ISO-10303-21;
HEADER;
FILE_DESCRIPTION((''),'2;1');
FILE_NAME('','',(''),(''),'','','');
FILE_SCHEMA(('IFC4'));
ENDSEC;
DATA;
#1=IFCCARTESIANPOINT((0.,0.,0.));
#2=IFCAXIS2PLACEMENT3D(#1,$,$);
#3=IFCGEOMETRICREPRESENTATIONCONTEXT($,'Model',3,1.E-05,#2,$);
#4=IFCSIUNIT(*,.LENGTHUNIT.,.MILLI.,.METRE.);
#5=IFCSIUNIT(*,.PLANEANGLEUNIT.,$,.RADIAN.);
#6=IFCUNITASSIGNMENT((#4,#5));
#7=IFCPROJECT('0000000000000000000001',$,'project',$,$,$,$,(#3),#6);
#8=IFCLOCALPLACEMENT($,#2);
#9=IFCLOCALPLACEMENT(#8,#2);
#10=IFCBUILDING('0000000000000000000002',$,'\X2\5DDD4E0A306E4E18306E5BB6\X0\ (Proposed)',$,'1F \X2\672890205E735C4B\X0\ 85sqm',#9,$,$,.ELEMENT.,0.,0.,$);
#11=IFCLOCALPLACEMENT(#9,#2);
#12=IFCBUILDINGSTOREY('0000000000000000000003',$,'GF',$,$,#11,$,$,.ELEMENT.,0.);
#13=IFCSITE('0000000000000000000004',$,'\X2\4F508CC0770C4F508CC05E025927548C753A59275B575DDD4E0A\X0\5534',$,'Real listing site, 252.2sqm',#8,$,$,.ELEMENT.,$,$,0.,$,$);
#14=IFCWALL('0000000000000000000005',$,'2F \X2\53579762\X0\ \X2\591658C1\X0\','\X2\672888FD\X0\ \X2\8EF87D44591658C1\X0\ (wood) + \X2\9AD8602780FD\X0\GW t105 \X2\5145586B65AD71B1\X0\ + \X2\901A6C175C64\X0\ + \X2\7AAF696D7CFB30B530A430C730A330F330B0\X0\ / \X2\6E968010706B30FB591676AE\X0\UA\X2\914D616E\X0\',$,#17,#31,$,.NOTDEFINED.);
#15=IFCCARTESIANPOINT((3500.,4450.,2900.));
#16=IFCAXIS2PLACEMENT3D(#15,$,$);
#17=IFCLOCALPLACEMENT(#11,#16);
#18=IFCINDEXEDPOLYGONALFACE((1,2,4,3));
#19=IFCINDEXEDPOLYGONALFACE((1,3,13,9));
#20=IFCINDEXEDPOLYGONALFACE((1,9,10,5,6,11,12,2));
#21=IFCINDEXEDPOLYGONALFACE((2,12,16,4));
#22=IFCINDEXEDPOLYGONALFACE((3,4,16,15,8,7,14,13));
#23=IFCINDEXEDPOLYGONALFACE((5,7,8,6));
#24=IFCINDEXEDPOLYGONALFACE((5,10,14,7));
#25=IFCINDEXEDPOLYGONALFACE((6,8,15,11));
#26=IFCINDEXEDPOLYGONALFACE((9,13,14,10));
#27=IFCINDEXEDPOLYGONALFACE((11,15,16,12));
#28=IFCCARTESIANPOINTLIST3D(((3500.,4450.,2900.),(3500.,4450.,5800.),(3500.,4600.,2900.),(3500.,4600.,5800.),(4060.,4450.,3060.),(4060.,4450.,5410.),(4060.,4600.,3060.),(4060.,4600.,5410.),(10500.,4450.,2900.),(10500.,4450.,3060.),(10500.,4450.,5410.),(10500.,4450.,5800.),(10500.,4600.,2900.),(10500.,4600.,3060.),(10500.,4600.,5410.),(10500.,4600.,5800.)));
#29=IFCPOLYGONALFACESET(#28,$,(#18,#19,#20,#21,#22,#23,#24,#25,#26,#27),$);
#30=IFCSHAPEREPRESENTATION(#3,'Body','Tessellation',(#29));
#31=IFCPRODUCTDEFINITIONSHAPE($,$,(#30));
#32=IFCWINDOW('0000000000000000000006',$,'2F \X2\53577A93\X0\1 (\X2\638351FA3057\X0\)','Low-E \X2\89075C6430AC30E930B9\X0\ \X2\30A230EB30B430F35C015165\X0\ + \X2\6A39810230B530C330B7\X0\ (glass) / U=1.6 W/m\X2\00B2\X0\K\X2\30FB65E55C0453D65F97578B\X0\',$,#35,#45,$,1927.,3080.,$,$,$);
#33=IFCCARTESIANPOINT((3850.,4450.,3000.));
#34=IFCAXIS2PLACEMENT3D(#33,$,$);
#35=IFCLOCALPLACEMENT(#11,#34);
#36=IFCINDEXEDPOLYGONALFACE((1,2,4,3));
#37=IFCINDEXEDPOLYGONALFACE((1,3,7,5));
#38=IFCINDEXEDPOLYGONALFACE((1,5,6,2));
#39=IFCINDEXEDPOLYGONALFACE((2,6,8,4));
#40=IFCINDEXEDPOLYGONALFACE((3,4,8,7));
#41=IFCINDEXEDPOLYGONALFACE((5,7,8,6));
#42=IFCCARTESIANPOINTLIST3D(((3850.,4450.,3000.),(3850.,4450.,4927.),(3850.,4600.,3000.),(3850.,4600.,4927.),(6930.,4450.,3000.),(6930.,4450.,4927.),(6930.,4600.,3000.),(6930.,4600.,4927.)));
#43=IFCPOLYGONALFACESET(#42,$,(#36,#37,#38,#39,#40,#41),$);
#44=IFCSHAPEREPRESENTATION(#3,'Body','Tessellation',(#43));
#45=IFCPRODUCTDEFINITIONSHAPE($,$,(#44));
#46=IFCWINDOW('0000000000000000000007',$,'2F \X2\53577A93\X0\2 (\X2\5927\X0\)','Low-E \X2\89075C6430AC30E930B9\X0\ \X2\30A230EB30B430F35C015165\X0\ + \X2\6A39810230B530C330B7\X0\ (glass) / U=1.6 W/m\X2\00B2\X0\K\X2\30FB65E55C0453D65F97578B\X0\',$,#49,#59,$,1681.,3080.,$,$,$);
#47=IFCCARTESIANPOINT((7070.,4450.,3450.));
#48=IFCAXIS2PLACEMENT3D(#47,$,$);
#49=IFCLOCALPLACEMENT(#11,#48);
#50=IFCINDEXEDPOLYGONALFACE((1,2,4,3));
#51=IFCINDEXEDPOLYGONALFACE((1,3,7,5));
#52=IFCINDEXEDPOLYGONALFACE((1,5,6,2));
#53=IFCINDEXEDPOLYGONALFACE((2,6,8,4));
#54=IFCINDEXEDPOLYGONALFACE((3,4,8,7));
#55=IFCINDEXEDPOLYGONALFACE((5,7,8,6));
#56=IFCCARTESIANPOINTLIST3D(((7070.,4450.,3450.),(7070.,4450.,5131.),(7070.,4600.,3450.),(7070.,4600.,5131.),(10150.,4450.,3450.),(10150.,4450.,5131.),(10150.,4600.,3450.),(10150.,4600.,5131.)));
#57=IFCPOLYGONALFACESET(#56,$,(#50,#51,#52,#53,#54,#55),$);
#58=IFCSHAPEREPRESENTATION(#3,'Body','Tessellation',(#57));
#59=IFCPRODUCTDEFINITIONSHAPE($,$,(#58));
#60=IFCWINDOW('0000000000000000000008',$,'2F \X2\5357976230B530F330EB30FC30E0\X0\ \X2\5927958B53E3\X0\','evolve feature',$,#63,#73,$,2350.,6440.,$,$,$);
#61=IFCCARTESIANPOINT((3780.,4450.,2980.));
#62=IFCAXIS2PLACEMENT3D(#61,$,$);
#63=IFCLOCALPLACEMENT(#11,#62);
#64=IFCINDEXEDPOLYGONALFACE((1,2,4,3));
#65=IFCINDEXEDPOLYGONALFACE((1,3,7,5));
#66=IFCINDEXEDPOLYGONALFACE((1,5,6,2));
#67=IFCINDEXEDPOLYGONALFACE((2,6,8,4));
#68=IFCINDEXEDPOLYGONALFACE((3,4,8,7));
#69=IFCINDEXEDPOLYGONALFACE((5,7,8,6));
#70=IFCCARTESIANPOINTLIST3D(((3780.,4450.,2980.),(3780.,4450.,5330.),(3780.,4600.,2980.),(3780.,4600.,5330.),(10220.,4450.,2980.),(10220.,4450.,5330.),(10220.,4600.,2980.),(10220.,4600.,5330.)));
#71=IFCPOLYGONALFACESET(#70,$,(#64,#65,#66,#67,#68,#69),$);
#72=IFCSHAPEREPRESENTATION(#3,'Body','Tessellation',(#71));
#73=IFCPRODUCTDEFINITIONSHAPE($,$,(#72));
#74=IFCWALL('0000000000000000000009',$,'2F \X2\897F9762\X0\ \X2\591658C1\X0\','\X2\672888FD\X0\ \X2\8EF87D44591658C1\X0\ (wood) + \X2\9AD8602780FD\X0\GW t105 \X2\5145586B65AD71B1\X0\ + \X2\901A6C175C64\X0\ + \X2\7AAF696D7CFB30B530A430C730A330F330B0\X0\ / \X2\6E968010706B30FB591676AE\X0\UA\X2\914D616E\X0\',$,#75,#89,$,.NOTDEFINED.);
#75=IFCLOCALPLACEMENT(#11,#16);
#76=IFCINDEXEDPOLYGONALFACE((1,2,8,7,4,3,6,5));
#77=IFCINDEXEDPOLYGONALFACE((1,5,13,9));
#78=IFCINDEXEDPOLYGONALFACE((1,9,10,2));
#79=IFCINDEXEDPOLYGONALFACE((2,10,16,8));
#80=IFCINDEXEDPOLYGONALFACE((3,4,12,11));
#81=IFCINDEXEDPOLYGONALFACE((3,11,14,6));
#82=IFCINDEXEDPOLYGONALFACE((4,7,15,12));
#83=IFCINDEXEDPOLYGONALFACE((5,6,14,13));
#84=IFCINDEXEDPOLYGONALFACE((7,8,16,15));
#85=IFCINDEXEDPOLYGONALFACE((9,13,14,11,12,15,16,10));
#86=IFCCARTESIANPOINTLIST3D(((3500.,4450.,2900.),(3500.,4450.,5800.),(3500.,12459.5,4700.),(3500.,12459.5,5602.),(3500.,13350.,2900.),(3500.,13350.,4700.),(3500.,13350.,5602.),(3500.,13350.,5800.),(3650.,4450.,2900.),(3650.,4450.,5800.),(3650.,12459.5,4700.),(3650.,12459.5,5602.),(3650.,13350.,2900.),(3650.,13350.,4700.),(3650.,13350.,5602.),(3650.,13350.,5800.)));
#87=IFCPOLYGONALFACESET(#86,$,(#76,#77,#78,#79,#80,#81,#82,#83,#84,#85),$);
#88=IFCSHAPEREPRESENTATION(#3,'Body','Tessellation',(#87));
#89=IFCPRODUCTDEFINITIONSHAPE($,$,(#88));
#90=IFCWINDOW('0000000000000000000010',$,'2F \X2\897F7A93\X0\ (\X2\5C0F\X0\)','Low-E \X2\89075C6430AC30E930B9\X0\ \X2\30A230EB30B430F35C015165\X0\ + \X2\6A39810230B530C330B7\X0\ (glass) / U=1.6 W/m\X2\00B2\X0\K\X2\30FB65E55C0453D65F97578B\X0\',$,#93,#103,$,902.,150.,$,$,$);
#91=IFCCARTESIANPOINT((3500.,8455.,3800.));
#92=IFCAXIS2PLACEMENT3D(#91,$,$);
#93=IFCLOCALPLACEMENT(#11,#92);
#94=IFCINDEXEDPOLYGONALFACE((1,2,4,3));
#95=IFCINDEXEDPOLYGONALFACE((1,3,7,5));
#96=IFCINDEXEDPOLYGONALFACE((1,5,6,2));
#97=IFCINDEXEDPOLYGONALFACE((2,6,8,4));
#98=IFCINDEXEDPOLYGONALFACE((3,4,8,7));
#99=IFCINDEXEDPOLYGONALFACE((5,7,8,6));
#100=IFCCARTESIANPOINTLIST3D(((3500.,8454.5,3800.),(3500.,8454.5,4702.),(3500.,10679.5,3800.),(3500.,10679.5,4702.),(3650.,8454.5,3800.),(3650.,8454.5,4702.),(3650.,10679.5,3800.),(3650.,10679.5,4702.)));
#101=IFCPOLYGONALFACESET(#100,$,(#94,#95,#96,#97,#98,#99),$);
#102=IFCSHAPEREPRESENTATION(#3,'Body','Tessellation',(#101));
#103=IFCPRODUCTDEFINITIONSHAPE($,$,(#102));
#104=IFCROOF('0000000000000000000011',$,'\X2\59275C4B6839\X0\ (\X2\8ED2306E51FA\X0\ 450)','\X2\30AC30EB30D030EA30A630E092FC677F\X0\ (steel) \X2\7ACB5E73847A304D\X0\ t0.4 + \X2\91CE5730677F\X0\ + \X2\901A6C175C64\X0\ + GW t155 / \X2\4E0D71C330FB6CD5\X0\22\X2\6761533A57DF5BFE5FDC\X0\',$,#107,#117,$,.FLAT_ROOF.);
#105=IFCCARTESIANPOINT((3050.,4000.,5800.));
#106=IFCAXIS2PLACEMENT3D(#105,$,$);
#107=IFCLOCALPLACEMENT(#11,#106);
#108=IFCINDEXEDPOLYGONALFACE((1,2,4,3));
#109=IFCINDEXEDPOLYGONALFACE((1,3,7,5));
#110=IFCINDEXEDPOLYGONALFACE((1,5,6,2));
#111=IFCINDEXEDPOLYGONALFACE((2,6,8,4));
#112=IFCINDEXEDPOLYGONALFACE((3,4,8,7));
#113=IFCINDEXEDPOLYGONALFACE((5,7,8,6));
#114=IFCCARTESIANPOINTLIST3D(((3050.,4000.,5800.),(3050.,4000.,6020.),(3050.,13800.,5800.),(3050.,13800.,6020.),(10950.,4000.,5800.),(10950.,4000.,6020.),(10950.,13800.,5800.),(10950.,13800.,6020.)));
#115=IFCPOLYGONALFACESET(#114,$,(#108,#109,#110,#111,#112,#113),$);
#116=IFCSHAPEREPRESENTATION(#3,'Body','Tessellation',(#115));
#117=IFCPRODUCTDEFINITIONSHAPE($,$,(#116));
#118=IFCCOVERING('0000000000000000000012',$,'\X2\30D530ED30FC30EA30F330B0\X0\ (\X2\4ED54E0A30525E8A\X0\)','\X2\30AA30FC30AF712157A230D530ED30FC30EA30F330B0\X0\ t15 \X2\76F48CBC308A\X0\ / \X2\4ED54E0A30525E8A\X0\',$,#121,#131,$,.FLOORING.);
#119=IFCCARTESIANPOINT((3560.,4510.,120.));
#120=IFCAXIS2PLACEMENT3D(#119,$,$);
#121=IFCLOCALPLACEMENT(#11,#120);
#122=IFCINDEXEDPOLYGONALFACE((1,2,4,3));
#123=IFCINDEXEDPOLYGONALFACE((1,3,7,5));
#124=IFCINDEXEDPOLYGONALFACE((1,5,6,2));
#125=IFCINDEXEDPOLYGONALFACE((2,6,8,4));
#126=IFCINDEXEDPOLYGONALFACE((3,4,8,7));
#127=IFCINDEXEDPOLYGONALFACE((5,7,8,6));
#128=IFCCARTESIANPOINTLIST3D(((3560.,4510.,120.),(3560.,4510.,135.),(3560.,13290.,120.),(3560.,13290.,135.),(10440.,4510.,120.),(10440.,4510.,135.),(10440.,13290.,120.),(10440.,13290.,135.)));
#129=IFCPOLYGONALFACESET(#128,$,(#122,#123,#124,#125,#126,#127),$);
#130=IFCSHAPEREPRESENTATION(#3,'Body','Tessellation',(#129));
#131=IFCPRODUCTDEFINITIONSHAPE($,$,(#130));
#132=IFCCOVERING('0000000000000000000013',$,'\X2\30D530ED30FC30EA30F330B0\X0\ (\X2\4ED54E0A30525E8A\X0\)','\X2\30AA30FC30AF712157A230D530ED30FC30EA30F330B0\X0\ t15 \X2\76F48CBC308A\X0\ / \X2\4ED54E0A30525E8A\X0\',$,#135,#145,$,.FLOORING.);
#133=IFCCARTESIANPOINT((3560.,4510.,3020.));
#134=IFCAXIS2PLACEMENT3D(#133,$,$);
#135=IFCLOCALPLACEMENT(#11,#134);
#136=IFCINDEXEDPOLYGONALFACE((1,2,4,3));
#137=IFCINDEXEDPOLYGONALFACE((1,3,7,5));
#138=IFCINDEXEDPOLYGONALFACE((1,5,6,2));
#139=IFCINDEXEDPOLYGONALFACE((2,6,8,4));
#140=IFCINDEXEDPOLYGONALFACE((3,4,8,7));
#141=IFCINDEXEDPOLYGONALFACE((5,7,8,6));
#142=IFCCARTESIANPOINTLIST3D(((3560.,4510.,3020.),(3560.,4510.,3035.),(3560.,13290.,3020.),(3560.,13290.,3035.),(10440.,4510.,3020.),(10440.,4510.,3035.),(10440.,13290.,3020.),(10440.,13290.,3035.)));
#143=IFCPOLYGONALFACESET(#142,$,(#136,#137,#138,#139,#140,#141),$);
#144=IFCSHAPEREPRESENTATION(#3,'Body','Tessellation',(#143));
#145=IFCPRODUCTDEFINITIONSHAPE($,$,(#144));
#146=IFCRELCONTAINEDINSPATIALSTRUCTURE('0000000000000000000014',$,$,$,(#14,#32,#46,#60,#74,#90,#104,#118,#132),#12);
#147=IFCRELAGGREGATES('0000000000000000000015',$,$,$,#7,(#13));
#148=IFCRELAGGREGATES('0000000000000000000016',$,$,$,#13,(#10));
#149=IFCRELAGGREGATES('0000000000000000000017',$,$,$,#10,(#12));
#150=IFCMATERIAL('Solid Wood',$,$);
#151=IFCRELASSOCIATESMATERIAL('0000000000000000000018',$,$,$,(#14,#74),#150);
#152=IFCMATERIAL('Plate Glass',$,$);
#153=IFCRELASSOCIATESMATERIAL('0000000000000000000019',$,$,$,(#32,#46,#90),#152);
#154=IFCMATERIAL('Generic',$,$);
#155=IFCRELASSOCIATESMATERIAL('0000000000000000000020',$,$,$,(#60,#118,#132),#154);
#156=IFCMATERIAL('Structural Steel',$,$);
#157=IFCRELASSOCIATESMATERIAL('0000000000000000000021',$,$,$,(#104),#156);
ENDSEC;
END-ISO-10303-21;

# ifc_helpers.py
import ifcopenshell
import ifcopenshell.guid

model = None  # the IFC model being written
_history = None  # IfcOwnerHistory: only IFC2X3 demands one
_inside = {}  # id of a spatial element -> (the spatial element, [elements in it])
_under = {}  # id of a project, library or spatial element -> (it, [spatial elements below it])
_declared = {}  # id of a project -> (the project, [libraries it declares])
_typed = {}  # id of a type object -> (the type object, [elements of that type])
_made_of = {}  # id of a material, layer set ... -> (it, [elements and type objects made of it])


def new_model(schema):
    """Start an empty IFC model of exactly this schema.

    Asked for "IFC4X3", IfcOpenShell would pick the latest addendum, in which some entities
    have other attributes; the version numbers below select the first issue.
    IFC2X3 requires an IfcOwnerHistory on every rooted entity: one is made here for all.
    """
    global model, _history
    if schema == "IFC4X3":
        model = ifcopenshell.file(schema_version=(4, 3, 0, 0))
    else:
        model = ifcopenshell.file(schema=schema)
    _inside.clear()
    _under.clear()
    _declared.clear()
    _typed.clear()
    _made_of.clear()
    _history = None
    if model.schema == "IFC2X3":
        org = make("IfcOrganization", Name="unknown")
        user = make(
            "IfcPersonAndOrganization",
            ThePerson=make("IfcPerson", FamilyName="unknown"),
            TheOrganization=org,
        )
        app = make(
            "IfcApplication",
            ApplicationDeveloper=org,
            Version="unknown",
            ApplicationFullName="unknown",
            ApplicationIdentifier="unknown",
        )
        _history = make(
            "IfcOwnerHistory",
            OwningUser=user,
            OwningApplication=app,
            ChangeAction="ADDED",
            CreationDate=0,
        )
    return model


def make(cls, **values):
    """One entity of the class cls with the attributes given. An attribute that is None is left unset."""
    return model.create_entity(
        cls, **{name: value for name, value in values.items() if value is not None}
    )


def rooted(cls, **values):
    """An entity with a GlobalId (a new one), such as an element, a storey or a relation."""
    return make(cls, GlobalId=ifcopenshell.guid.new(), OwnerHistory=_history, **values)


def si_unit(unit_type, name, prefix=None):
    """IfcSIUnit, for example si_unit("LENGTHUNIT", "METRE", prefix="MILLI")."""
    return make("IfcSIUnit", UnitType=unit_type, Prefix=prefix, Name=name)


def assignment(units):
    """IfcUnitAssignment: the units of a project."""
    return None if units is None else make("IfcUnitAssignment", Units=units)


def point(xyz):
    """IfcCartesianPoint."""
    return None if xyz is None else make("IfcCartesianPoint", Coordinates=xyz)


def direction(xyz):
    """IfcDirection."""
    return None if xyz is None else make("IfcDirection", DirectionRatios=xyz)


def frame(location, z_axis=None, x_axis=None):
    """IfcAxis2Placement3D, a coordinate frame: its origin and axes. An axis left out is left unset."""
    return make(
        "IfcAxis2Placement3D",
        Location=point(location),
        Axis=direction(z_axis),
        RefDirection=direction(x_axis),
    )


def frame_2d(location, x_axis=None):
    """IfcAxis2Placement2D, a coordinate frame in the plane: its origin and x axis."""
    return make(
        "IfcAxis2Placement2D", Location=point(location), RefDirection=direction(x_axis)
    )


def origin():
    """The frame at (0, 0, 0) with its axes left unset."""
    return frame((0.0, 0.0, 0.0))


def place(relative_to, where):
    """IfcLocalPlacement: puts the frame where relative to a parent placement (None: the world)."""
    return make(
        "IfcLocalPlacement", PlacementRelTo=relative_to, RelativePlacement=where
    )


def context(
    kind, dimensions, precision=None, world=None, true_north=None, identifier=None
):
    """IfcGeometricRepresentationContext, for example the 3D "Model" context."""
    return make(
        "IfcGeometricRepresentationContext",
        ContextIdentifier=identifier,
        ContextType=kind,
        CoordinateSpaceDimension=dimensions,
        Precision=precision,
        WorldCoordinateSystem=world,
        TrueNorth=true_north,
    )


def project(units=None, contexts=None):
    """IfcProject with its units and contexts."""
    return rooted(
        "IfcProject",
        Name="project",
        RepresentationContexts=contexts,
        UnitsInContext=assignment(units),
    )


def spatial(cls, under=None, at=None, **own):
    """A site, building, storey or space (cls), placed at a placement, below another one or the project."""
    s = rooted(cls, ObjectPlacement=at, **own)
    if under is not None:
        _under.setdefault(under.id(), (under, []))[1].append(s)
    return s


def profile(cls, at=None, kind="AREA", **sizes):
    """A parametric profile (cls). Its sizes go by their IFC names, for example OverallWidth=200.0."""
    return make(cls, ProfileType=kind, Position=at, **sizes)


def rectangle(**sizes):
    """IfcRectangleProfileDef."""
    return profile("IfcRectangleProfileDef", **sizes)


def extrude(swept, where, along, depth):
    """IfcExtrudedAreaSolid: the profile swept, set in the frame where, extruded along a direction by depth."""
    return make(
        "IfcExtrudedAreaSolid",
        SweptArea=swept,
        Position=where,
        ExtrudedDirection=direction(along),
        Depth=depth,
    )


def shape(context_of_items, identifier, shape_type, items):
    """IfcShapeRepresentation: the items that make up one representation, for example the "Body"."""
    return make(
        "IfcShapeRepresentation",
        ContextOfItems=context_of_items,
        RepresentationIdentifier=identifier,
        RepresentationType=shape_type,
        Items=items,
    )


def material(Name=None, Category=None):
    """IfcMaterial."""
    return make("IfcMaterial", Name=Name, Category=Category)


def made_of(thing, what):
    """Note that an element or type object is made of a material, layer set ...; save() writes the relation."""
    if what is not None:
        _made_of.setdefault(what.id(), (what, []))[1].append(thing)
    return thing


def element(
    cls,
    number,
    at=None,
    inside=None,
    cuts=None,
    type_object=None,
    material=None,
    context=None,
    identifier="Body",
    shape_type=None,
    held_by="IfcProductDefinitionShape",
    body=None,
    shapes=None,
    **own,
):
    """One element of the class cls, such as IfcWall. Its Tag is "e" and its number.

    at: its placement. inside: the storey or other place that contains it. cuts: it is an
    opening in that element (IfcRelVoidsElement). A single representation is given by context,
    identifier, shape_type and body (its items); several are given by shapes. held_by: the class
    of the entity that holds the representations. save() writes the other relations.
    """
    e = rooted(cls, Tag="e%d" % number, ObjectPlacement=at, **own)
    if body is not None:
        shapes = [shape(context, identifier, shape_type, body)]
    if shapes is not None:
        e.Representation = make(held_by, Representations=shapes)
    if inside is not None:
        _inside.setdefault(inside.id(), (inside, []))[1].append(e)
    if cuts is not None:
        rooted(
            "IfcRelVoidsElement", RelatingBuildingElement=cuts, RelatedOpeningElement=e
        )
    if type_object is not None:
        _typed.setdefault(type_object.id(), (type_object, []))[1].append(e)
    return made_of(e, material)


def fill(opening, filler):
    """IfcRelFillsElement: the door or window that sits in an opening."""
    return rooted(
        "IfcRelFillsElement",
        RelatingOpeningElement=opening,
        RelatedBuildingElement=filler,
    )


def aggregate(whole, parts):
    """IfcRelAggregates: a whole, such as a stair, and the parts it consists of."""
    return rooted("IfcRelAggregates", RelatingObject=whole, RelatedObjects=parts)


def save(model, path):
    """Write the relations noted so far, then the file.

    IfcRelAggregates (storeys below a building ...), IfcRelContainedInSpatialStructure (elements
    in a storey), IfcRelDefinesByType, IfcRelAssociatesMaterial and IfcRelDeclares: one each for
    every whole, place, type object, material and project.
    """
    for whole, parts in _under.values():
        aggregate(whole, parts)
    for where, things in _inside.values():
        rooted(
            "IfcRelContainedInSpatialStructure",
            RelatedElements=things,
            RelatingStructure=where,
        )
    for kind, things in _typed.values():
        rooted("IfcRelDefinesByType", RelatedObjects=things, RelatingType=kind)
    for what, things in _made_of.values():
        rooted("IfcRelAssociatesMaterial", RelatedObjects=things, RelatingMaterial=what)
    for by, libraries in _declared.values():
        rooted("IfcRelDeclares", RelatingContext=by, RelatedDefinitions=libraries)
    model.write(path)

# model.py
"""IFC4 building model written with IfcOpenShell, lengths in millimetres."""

from ifc_helpers import new_model, si_unit, frame, frame_2d, origin, place, context, project, spatial, rectangle, extrude, material, element, fill, save


model = new_model("IFC4")

# Units and contexts
model_context = context("Model", 3, precision=1e-05, world=origin())
ifc_project = project(units=[si_unit("LENGTHUNIT", "METRE", prefix="MILLI"), si_unit("PLANEANGLEUNIT", "RADIAN")], contexts=[model_context])

# Site, building, storey
site_placement = place(None, origin())
site = spatial("IfcSite", under=ifc_project, at=site_placement, Name="佐賀県佐賀市大和町大字川上5534", ObjectType="Real listing site, 252.2sqm", CompositionType="ELEMENT", RefElevation=0.0)
building_placement = place(site_placement, origin())
building = spatial("IfcBuilding", under=site, at=building_placement, Name="川上の丘の家 (Proposed)", ObjectType="1F 木造平屋 85sqm", CompositionType="ELEMENT", ElevationOfRefHeight=0.0, ElevationOfTerrain=0.0)
storey_placement = place(building_placement, origin())
storey = spatial("IfcBuildingStorey", under=building, at=storey_placement, Name="GF", CompositionType="ELEMENT", Elevation=0.0)

# Shared definitions
ifc_material_1 = material(Name="Solid Wood")
ifc_material_2 = material(Name="Generic")

# Shared definitions
ifc_material_3 = material(Name="Plate Glass")

# Wall, openings, windows
wall_1_placement = place(storey_placement, frame((3500.0, 4450.0, 2900.0)))
wall_1 = element("IfcWall", 1, at=wall_1_placement, inside=storey, material=ifc_material_1, Name="2F 南面 外壁", Description="木製 軸組外壁 (wood) + 高性能GW t105 充填断熱 + 通気層 + 窯業系サイディング / 準耐火・外皮UA配慮", PredefinedType="NOTDEFINED", context=model_context, shape_type="SweptSolid", body=[
    extrude(rectangle(XDim=7000.0, YDim=150.0, at=frame_2d((3500.0, 75.0))), frame((3500.0, 4450.0, 2900.0)), (0.0, 0.0, 1.0), 2900.0),
])
opening_1_placement = place(storey_placement, frame((3850.0, 4450.0, 3000.0)))
opening_1 = element("IfcOpeningElement", 2, at=opening_1_placement, cuts=wall_1, PredefinedType="NOTDEFINED", context=model_context, shape_type="SweptSolid", body=[
    extrude(rectangle(XDim=3080.0, YDim=150.0, at=frame_2d((1540.0, 75.0))), frame((3850.0, 4450.0, 3000.0)), (0.0, 0.0, 1.0), 1927.0),
])
opening_2_placement = place(storey_placement, frame((7070.0, 4450.0, 3450.0)))
opening_2 = element("IfcOpeningElement", 3, at=opening_2_placement, cuts=wall_1, PredefinedType="NOTDEFINED", context=model_context, shape_type="SweptSolid", body=[
    extrude(rectangle(XDim=3080.0, YDim=150.0, at=frame_2d((1540.0, 75.0))), frame((7070.0, 4450.0, 3450.0)), (0.0, 0.0, 1.0), 1681.0),
])
opening_3_placement = place(storey_placement, frame((3780.0, 4450.0, 2980.0)))
opening_3 = element("IfcOpeningElement", 4, at=opening_3_placement, cuts=wall_1, PredefinedType="NOTDEFINED", context=model_context, shape_type="SweptSolid", body=[
    extrude(rectangle(XDim=6440.0, YDim=150.0, at=frame_2d((3220.0, 75.0))), frame((3780.0, 4450.0, 2980.0)), (0.0, 0.0, 1.0), 2350.0),
])
window_1_placement = place(storey_placement, frame((3850.0, 4450.0, 3000.0)))
window_1 = element("IfcWindow", 5, at=window_1_placement, inside=storey, material=ifc_material_3, Name="2F 南窓1 (掃出し)", Description="Low-E 複層ガラス アルゴン封入 + 樹脂サッシ (glass) / U=1.6 W/m²K・日射取得型", OverallHeight=1927.0, OverallWidth=3080.0, context=model_context, shape_type="SweptSolid", body=[
    extrude(rectangle(XDim=3080.0, YDim=150.0, at=frame_2d((1540.0, 75.0))), frame((3850.0, 4450.0, 3000.0)), (0.0, 0.0, 1.0), 1927.0),
])
fill(opening_1, window_1)
window_2_placement = place(storey_placement, frame((7070.0, 4450.0, 3450.0)))
window_2 = element("IfcWindow", 6, at=window_2_placement, inside=storey, material=ifc_material_3, Name="2F 南窓2 (大)", Description="Low-E 複層ガラス アルゴン封入 + 樹脂サッシ (glass) / U=1.6 W/m²K・日射取得型", OverallHeight=1681.0, OverallWidth=3080.0, context=model_context, shape_type="SweptSolid", body=[
    extrude(rectangle(XDim=3080.0, YDim=150.0, at=frame_2d((1540.0, 75.0))), frame((7070.0, 4450.0, 3450.0)), (0.0, 0.0, 1.0), 1681.0),
])
fill(opening_2, window_2)
window_3_placement = place(storey_placement, frame((3780.0, 4450.0, 2980.0)))
window_3 = element("IfcWindow", 7, at=window_3_placement, inside=storey, material=ifc_material_2, Name="2F 南面サンルーム 大開口", Description="evolve feature", OverallHeight=2350.0, OverallWidth=6440.0, context=model_context, shape_type="SweptSolid", body=[
    extrude(rectangle(XDim=6440.0, YDim=150.0, at=frame_2d((3220.0, 75.0))), frame((3780.0, 4450.0, 2980.0)), (0.0, 0.0, 1.0), 2350.0),
])
fill(opening_3, window_3)

# Wall, opening, window
wall_2_placement = place(storey_placement, frame((3500.0, 4450.0, 2900.0)))
wall_2 = element("IfcWall", 8, at=wall_2_placement, inside=storey, material=ifc_material_1, Name="2F 西面 外壁", Description="木製 軸組外壁 (wood) + 高性能GW t105 充填断熱 + 通気層 + 窯業系サイディング / 準耐火・外皮UA配慮", PredefinedType="NOTDEFINED", context=model_context, shape_type="SweptSolid", body=[
    extrude(rectangle(XDim=150.0, YDim=8900.0, at=frame_2d((75.0, 4450.0))), frame((3500.0, 4450.0, 2900.0)), (0.0, 0.0, 1.0), 2900.0),
])
opening_4_placement = place(storey_placement, frame((3500.0, 8455.0, 3800.0)))
opening_4 = element("IfcOpeningElement", 9, at=opening_4_placement, cuts=wall_2, PredefinedType="NOTDEFINED", context=model_context, shape_type="SweptSolid", body=[
    extrude(rectangle(XDim=150.0, YDim=2225.0, at=frame_2d((75.0, 1112.0))), frame((3500.0, 8455.0, 3800.0)), (0.0, 0.0, 1.0), 902.0),
])
window_4_placement = place(storey_placement, frame((3500.0, 8455.0, 3800.0)))
window_4 = element("IfcWindow", 10, at=window_4_placement, inside=storey, material=ifc_material_3, Name="2F 西窓 (小)", Description="Low-E 複層ガラス アルゴン封入 + 樹脂サッシ (glass) / U=1.6 W/m²K・日射取得型", OverallHeight=902.0, OverallWidth=150.0, context=model_context, shape_type="SweptSolid", body=[
    extrude(rectangle(XDim=150.0, YDim=2225.0, at=frame_2d((75.0, 1112.0))), frame((3500.0, 8455.0, 3800.0)), (0.0, 0.0, 1.0), 902.0),
])
fill(opening_4, window_4)

# Roof
ifc_material_4 = material(Name="Structural Steel")
roof_placement = place(storey_placement, frame((3050.0, 4000.0, 5800.0)))
element("IfcRoof", 11, at=roof_placement, inside=storey, material=ifc_material_4, Name="大屋根 (軒の出 450)", Description="ガルバリウム鋼板 (steel) 立平葺き t0.4 + 野地板 + 通気層 + GW t155 / 不燃・法22条区域対応", PredefinedType="FLAT_ROOF", context=model_context, shape_type="SweptSolid", body=[
    extrude(rectangle(XDim=7900.0, YDim=9800.0, at=frame_2d((3950.0, 4900.0))), frame((3050.0, 4000.0, 5800.0)), (0.0, 0.0, 1.0), 220.0),
])

# Coverings
covering_1_placement = place(storey_placement, frame((3560.0, 4510.0, 120.0)))
element("IfcCovering", 12, at=covering_1_placement, inside=storey, material=ifc_material_2, Name="フローリング (仕上げ床)", Description="オーク無垢フローリング t15 直貼り / 仕上げ床", PredefinedType="FLOORING", context=model_context, shape_type="SweptSolid", body=[
    extrude(rectangle(XDim=6880.0, YDim=8780.0, at=frame_2d((3440.0, 4390.0))), frame((3560.0, 4510.0, 120.0)), (0.0, 0.0, 1.0), 15.0),
])
covering_2_placement = place(storey_placement, frame((3560.0, 4510.0, 3020.0)))
element("IfcCovering", 13, at=covering_2_placement, inside=storey, material=ifc_material_2, Name="フローリング (仕上げ床)", Description="オーク無垢フローリング t15 直貼り / 仕上げ床", PredefinedType="FLOORING", context=model_context, shape_type="SweptSolid", body=[
    extrude(rectangle(XDim=6880.0, YDim=8780.0, at=frame_2d((3440.0, 4390.0))), frame((3560.0, 4510.0, 3020.0)), (0.0, 0.0, 1.0), 15.0),
])

save(model, "model.ifc")
